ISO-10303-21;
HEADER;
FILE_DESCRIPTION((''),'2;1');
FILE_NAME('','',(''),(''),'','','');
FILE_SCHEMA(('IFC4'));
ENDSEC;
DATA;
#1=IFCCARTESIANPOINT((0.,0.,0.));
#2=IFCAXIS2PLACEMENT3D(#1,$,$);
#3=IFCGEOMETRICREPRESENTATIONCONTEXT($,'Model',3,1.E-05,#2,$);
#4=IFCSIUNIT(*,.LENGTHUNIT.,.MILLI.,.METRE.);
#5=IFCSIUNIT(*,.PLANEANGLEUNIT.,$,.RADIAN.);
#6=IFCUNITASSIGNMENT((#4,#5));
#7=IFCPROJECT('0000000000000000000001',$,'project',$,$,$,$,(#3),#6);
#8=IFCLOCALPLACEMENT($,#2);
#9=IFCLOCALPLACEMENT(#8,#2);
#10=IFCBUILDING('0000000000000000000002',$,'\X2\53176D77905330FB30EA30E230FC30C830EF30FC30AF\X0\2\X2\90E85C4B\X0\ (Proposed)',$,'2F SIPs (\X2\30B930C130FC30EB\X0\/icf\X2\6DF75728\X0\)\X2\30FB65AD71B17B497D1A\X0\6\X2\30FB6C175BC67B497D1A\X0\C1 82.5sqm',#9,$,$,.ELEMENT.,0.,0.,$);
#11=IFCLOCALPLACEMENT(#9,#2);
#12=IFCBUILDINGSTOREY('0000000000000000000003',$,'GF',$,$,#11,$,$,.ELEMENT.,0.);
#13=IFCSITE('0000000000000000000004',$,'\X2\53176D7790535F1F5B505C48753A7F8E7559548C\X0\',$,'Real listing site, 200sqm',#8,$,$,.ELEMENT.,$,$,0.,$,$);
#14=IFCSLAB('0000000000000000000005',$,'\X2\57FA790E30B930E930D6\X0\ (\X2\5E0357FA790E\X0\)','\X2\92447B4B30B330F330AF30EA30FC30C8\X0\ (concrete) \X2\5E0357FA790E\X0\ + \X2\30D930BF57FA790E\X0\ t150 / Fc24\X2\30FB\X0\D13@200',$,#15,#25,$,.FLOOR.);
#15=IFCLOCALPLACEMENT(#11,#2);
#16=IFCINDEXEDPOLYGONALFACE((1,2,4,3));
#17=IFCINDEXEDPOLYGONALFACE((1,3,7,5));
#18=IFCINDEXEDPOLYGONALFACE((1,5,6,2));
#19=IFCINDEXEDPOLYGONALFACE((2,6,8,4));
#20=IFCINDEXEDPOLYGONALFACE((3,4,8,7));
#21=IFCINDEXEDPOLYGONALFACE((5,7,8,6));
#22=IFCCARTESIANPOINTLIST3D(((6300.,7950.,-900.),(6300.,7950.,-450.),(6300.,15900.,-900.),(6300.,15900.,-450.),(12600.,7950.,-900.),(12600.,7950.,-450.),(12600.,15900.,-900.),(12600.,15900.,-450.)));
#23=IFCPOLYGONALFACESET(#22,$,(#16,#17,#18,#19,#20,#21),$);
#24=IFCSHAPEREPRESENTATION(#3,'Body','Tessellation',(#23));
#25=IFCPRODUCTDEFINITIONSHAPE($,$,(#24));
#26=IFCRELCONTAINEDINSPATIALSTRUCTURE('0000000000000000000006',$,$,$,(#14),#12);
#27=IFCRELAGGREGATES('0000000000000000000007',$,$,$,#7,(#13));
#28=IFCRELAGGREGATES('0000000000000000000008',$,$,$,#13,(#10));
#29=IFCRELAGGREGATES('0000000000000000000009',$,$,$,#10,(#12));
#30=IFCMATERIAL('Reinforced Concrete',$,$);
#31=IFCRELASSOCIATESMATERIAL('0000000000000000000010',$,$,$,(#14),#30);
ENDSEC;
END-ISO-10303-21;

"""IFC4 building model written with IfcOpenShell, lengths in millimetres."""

from ifc_helpers import new_model, si_unit, frame, frame_2d, origin, place, context, project, spatial, rectangle, extrude, material, element, save


model = new_model("IFC4")

# Units and contexts
model_context = context("Model", 3, precision=1e-05, world=origin())
ifc_project = project(units=[si_unit("LENGTHUNIT", "METRE", prefix="MILLI"), si_unit("PLANEANGLEUNIT", "RADIAN")], contexts=[model_context])

# Site, building, storey
site_placement = place(None, origin())
site = spatial("IfcSite", under=ifc_project, at=site_placement, Name="北海道弟子屈町美留和", ObjectType="Real listing site, 200sqm", CompositionType="ELEMENT", RefElevation=0.0)
building_placement = place(site_placement, origin())
building = spatial("IfcBuilding", under=site, at=building_placement, Name="北海道・リモートワーク2部屋 (Proposed)", ObjectType="2F SIPs (スチール/icf混在)・断熱等級6・気密等級C1 82.5sqm", CompositionType="ELEMENT", ElevationOfRefHeight=0.0, ElevationOfTerrain=0.0)
storey_placement = place(building_placement, origin())
storey = spatial("IfcBuildingStorey", under=building, at=storey_placement, Name="GF", CompositionType="ELEMENT", Elevation=0.0)

# Slab
ifc_material_1 = material(Name="Reinforced Concrete")
slab_1_placement = place(storey_placement, frame((3150.0, 3975.0, -450.0)))
element("IfcSlab", 1, at=slab_1_placement, inside=storey, material=ifc_material_1, Name="基礎スラブ (布基礎)", Description="鉄筋コンクリート (concrete) 布基礎 + ベタ基礎 t150 / Fc24・D13@200", PredefinedType="FLOOR", context=model_context, shape_type="SweptSolid", body=[
    extrude(rectangle(XDim=6300.0, YDim=7950.0, at=frame_2d((3150.0, 3975.0))), frame((3150.0, 3975.0, -450.0)), (0.0, 0.0, 1.0), 450.0),
])

save(model, "model.ifc")
